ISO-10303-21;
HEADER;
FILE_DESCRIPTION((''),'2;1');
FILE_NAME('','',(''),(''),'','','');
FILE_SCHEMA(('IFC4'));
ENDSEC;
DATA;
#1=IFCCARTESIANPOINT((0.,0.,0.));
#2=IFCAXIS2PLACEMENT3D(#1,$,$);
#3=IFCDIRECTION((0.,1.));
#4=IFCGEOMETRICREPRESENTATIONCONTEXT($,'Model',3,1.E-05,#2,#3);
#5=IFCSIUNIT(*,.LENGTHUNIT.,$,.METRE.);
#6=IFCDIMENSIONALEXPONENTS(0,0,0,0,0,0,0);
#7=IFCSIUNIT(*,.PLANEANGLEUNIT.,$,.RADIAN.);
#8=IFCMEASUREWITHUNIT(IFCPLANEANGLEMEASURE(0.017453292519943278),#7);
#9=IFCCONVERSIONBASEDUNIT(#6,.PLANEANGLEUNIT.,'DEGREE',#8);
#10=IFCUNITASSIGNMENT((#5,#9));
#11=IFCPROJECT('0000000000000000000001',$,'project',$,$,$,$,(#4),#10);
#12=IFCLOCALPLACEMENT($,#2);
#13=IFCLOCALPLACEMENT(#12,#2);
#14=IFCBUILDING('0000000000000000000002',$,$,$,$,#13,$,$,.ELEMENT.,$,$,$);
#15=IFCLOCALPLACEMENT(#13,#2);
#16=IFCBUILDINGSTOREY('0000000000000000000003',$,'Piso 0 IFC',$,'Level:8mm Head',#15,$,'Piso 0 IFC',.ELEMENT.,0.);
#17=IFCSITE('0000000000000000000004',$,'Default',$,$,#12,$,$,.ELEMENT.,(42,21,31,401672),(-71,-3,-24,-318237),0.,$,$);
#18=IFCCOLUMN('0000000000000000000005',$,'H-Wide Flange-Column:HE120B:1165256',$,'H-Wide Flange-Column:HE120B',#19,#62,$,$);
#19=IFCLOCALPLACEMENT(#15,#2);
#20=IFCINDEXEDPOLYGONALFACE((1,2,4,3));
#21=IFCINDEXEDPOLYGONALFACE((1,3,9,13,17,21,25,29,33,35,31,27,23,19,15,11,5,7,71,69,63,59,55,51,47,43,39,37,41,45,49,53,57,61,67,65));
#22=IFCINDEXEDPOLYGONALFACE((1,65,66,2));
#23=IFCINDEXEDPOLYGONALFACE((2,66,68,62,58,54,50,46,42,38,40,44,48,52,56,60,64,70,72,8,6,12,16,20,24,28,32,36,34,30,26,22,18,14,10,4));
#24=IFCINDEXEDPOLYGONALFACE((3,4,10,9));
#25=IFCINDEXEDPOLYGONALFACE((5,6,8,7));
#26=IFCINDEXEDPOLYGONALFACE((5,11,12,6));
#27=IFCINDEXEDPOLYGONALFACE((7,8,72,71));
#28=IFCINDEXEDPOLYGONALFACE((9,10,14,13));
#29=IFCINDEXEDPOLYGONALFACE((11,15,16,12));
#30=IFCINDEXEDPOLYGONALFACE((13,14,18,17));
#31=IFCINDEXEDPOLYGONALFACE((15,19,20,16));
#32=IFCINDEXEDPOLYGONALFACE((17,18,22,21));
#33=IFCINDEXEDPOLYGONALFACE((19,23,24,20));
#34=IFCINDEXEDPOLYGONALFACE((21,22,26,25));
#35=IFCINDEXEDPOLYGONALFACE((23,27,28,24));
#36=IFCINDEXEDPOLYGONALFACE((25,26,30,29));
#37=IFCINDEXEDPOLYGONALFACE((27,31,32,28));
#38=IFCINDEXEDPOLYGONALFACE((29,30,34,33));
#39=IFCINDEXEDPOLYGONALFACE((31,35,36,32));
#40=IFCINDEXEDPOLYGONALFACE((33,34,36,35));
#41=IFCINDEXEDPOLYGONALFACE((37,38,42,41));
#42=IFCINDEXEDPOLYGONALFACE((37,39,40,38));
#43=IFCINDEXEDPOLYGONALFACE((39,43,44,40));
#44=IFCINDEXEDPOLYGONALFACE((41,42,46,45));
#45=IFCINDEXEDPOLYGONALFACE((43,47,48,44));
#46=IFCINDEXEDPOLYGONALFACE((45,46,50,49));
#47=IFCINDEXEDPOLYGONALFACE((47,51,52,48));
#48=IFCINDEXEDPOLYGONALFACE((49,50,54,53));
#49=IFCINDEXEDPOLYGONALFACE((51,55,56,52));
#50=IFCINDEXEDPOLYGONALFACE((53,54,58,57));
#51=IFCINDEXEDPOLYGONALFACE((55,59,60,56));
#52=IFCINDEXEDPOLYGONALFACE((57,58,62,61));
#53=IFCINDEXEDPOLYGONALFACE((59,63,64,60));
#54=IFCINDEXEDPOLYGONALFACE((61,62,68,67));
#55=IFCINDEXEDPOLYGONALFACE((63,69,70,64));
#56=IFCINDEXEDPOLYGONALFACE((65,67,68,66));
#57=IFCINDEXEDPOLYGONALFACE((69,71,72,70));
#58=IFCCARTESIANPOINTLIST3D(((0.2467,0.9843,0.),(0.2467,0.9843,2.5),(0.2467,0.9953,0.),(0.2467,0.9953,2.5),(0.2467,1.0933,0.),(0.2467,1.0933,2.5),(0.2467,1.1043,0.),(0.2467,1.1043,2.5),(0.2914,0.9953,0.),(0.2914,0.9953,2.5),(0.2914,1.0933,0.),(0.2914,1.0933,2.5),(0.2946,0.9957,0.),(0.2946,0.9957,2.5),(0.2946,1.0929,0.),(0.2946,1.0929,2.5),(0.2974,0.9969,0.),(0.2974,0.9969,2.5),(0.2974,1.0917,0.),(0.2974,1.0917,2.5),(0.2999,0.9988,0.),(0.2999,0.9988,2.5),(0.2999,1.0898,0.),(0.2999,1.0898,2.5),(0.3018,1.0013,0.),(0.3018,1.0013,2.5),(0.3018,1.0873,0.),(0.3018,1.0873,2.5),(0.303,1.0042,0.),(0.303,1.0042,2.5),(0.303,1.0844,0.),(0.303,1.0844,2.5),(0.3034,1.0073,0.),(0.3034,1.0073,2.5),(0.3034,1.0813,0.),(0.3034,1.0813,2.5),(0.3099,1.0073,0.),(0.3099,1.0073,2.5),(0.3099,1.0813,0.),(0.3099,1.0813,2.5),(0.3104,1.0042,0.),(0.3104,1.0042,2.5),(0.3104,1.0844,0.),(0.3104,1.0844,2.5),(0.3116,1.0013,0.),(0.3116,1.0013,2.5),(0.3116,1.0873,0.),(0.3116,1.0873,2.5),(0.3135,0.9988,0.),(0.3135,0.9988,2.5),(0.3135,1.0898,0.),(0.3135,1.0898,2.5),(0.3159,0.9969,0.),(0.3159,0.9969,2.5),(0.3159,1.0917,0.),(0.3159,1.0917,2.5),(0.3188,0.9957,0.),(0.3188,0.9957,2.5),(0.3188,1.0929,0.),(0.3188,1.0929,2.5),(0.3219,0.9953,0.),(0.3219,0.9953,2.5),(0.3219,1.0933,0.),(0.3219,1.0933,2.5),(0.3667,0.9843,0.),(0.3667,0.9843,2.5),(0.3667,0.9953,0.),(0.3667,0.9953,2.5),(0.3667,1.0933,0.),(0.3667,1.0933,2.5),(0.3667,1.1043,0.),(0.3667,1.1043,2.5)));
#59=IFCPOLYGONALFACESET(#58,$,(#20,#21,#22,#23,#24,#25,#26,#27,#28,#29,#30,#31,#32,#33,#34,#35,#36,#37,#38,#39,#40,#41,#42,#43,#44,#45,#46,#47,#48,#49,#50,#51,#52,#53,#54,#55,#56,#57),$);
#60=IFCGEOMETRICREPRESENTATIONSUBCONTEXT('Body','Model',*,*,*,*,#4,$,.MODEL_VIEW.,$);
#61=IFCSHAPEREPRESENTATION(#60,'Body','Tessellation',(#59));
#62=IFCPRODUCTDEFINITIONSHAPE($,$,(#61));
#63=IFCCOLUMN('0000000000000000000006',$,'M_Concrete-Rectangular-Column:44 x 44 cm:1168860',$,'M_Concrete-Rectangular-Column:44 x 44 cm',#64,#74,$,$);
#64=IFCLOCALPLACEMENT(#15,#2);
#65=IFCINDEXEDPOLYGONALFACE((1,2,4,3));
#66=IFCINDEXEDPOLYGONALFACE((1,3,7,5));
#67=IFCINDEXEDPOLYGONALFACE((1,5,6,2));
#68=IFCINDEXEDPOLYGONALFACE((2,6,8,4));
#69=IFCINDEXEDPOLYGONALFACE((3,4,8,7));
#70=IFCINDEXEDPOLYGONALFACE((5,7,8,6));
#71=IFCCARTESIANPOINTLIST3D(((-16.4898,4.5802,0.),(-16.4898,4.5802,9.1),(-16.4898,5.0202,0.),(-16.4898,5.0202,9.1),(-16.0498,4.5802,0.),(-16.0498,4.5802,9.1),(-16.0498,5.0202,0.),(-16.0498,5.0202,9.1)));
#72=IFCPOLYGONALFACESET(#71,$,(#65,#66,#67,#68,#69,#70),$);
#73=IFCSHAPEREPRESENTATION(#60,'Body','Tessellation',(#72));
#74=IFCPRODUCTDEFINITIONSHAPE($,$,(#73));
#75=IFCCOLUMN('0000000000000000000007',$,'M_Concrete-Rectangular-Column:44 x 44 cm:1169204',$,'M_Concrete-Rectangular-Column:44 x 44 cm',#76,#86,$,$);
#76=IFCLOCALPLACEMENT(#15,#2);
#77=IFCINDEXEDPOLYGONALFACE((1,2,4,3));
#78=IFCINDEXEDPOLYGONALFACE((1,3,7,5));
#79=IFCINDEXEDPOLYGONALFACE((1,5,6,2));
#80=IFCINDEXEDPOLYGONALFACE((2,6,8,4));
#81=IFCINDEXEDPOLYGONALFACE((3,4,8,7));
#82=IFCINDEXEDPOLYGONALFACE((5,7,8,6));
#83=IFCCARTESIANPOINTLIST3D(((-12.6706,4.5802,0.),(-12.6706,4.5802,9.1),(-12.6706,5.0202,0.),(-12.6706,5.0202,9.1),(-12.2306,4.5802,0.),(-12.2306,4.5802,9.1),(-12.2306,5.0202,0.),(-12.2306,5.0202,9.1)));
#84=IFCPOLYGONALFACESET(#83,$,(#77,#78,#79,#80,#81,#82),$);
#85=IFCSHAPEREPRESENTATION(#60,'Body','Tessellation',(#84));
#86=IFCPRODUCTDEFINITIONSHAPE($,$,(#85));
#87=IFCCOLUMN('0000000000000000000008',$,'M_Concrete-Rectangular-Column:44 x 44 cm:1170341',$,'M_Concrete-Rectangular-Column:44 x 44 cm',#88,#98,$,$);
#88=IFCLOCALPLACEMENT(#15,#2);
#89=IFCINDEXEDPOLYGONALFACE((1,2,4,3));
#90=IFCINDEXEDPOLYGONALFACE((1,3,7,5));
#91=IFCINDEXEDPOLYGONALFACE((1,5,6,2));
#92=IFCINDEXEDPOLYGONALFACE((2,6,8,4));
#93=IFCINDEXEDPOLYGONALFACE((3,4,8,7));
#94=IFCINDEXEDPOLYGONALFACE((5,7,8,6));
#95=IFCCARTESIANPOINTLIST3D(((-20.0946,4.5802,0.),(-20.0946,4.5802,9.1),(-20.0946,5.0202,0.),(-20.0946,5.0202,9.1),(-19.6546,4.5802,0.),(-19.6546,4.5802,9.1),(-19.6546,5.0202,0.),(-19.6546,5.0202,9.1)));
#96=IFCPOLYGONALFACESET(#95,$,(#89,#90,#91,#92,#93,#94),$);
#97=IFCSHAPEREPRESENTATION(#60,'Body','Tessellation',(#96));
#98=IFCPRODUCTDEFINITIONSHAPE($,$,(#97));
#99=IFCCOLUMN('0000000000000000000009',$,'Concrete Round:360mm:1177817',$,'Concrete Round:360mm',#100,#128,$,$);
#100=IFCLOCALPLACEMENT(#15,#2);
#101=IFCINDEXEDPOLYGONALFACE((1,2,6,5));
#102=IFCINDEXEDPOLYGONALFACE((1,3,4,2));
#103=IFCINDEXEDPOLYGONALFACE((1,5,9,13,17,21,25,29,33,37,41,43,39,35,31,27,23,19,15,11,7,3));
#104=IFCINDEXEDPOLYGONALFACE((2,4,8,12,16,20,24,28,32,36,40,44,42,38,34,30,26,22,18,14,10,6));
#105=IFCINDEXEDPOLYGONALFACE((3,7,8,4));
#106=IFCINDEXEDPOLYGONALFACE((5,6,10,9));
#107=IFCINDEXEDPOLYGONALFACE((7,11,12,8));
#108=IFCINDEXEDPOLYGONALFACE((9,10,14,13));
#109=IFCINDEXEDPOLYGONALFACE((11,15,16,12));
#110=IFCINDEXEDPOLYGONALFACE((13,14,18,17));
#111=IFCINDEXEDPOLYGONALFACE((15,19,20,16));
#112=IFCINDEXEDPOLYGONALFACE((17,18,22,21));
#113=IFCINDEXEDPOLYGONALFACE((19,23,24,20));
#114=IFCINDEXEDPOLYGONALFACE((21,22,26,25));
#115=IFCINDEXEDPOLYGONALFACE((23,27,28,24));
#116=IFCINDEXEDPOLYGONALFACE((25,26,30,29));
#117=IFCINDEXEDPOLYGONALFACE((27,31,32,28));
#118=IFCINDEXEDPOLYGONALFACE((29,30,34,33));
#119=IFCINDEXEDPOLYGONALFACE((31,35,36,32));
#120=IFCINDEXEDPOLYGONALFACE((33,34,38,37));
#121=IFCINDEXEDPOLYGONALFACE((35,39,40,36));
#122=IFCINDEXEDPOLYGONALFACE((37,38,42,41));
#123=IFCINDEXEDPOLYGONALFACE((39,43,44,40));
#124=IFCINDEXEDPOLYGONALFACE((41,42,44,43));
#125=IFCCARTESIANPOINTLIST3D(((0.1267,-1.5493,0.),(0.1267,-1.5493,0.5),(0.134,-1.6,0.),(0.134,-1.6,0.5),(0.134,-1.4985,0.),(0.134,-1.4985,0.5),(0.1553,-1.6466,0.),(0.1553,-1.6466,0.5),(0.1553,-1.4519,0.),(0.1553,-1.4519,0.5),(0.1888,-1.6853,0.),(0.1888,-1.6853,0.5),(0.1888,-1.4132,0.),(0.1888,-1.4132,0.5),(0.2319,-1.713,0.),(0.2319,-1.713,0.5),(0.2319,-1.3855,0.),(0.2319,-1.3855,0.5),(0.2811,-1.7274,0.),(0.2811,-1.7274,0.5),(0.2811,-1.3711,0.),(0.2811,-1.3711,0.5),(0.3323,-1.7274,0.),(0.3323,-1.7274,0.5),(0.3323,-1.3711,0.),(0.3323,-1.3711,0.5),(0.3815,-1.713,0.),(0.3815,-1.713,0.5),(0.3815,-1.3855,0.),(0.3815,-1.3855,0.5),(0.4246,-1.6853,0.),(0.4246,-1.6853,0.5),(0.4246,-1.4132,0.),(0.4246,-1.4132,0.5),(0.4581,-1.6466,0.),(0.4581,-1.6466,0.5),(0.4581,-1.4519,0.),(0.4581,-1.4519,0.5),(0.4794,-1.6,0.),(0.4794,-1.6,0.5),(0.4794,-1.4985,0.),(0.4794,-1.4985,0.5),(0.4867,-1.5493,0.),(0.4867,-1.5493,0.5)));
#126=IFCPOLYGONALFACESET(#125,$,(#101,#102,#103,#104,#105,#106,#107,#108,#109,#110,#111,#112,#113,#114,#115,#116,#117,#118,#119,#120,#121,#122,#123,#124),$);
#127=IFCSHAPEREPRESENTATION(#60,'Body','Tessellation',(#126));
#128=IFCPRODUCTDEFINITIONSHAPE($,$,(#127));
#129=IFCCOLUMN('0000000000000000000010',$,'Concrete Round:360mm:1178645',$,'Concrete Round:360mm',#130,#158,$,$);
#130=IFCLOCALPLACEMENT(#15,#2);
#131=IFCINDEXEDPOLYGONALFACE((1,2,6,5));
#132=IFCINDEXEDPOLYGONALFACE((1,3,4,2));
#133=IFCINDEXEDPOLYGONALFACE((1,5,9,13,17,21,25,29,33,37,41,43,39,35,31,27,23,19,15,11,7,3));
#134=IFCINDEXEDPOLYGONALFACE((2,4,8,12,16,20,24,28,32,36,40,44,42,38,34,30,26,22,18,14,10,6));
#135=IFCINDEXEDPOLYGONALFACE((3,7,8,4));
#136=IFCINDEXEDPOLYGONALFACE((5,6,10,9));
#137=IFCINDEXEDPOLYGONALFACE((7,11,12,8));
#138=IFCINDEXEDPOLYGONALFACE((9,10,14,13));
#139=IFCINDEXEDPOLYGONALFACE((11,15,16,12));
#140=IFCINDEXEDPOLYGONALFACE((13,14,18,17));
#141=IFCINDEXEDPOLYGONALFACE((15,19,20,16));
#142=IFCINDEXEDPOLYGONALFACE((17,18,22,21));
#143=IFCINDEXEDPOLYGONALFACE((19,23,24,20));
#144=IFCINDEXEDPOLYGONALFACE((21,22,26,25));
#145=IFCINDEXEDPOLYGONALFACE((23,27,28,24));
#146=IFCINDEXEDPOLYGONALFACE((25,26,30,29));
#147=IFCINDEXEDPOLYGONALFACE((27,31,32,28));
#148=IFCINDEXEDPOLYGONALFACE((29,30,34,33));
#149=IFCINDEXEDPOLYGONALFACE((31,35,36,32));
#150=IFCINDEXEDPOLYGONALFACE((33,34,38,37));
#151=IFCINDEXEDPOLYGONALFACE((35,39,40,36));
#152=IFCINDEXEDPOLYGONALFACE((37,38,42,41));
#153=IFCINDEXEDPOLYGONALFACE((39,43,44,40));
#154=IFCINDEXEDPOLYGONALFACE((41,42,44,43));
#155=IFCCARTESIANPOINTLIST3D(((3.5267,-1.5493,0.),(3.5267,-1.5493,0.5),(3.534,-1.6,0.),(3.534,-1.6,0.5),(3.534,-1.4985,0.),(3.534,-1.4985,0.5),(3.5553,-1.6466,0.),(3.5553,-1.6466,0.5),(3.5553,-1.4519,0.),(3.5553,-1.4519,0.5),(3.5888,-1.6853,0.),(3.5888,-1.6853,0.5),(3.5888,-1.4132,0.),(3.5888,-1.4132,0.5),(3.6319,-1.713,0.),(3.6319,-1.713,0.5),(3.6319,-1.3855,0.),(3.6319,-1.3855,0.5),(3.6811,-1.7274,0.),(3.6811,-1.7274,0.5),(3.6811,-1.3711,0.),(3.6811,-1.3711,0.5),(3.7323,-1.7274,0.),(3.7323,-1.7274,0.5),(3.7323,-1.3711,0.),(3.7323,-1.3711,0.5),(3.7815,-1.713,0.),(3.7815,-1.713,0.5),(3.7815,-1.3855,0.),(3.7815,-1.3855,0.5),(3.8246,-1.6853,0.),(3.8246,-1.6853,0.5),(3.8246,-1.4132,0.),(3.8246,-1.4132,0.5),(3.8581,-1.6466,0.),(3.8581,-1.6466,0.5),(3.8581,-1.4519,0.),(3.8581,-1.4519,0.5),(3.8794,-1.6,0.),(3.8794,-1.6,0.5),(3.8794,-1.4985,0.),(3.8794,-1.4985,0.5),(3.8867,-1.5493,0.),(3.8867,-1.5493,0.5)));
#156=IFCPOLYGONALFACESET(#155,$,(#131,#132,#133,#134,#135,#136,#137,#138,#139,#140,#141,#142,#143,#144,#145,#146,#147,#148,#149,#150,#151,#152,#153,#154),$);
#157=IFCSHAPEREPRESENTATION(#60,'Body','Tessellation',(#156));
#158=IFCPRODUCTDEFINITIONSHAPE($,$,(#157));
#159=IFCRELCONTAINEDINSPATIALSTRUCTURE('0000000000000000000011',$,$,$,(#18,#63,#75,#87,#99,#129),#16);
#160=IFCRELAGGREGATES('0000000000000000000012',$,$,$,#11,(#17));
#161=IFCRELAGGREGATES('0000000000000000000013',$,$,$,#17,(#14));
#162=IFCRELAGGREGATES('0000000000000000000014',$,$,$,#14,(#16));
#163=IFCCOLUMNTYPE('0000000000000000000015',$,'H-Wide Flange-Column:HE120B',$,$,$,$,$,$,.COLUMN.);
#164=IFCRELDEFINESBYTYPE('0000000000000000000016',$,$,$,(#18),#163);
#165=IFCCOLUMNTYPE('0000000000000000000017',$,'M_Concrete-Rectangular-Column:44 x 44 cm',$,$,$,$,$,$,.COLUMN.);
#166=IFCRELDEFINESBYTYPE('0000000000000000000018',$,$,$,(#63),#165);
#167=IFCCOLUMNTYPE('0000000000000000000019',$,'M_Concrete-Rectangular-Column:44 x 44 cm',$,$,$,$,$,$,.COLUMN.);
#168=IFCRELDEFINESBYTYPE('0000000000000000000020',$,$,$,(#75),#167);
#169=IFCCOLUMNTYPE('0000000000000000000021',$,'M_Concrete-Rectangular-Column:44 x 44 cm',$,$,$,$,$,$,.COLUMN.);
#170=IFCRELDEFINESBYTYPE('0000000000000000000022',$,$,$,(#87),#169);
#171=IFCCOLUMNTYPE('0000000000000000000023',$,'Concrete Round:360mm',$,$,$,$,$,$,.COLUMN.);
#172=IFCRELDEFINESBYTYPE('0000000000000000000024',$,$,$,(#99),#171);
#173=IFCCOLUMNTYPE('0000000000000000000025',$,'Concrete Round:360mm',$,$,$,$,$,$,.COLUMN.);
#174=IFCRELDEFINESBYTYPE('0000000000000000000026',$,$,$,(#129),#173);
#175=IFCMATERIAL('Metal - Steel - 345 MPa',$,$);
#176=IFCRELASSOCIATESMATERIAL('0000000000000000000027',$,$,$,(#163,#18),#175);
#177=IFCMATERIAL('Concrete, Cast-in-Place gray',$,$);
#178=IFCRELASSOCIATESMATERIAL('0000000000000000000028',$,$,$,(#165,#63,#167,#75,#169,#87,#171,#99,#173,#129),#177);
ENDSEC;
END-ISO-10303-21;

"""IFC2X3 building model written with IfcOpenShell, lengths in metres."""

from ifc_helpers import new_model, entity, si_unit, converted_unit, direction, frame, frame_2d, origin, place, context, subcontext, project, spatial, rectangle, circle, i_section, extrude, source, transform, mapped, material, type_object, type_shapes, element, save


model = new_model("IFC2X3")

# Units and contexts
model_context = context("Model", 3, precision=1e-05, world=origin(), true_north=direction((0.0, 1.0)))
body_context = subcontext(model_context, "Body", "Model", "MODEL_VIEW")
ifc_project = project(units=[si_unit("LENGTHUNIT", "METRE"), converted_unit("PLANEANGLEUNIT", "DEGREE", entity("IfcPlaneAngleMeasure", 0.017453292519943278), si_unit("PLANEANGLEUNIT", "RADIAN"), dimensions=[0, 0, 0, 0, 0, 0, 0])], contexts=[model_context])

# Site, building, storey
site_placement = place(None, origin())
site = spatial("IfcSite", under=ifc_project, at=site_placement, Name="Default", CompositionType="ELEMENT", RefLatitude=(42, 21, 31, 401672), RefLongitude=(-71, -3, -24, -318237), RefElevation=0.0)
building_placement = place(site_placement, origin())
building = spatial("IfcBuilding", under=site, at=building_placement, CompositionType="ELEMENT")
storey_placement = place(building_placement, origin())
storey = spatial("IfcBuildingStorey", under=building, at=storey_placement, Name="Piso 0 IFC", ObjectType="Level:8mm Head", LongName="Piso 0 IFC", CompositionType="ELEMENT", Elevation=0.0)

# Columns
ifc_material_1 = material(Name="Metal - Steel - 345 MPa")
column_type_1 = type_object("IfcColumnType", Name="H-Wide Flange-Column:HE120B", PredefinedType="COLUMN", material=ifc_material_1)
shared_shape_1 = source(origin(), body_context, "Body", "SweptSolid", [
    extrude(i_section(OverallWidth=0.12, OverallDepth=0.12, WebThickness=0.0065, FlangeThickness=0.011, FilletRadius=0.012, at=frame_2d((0.0, 0.0), x_axis=(1.0, 0.0))), frame((0.0, 0.0, 0.0), z_axis=(0.0, 0.0, 1.0), x_axis=(-1.0, 0.0, 0.0)), (0.0, 0.0, 1.0), 2.5),
])
type_shapes(column_type_1, [shared_shape_1])
column_1_placement = place(storey_placement, frame((0.3067, 1.0443, 0.0)))
element("IfcColumn", 1, at=column_1_placement, inside=storey, type_object=column_type_1, material=ifc_material_1, Name="H-Wide Flange-Column:HE120B:1165256", ObjectType="H-Wide Flange-Column:HE120B", context=body_context, shape_type="MappedRepresentation", body=[
    mapped(shared_shape_1, transform((0.0, 0.0, 0.0), scale=1.0)),
])
ifc_material_2 = material(Name="Concrete, Cast-in-Place gray")
column_type_2 = type_object("IfcColumnType", Name="M_Concrete-Rectangular-Column:44 x 44 cm", PredefinedType="COLUMN", material=ifc_material_2)
shared_shape_2 = source(origin(), body_context, "Body", "SweptSolid", [
    extrude(rectangle(XDim=0.44, YDim=0.44, at=frame_2d((0.0, 0.0), x_axis=(1.0, 0.0))), frame((-16.2698, 4.8002, 0.0), z_axis=(0.0, 0.0, 1.0), x_axis=(-1.0, 0.0, 0.0)), (0.0, 0.0, 1.0), 9.1),
])
type_shapes(column_type_2, [shared_shape_2])
column_2_placement = place(storey_placement, origin())
element("IfcColumn", 2, at=column_2_placement, inside=storey, type_object=column_type_2, material=ifc_material_2, Name="M_Concrete-Rectangular-Column:44 x 44 cm:1168860", ObjectType="M_Concrete-Rectangular-Column:44 x 44 cm", context=body_context, shape_type="MappedRepresentation", body=[
    mapped(shared_shape_2, transform((0.0, 0.0, 0.0), scale=1.0)),
])
column_type_3 = type_object("IfcColumnType", Name="M_Concrete-Rectangular-Column:44 x 44 cm", PredefinedType="COLUMN", material=ifc_material_2)
shared_shape_3 = source(origin(), body_context, "Body", "SweptSolid", [
    extrude(rectangle(XDim=0.44, YDim=0.44, at=frame_2d((0.0, 0.0), x_axis=(1.0, 0.0))), frame((-12.4506, 4.8002, 0.0), z_axis=(0.0, 0.0, 1.0), x_axis=(-1.0, 0.0, 0.0)), (0.0, 0.0, 1.0), 9.1),
])
type_shapes(column_type_3, [shared_shape_3])
column_3_placement = place(storey_placement, origin())
element("IfcColumn", 3, at=column_3_placement, inside=storey, type_object=column_type_3, material=ifc_material_2, Name="M_Concrete-Rectangular-Column:44 x 44 cm:1169204", ObjectType="M_Concrete-Rectangular-Column:44 x 44 cm", context=body_context, shape_type="MappedRepresentation", body=[
    mapped(shared_shape_3, transform((0.0, 0.0, 0.0), scale=1.0)),
])
column_type_4 = type_object("IfcColumnType", Name="M_Concrete-Rectangular-Column:44 x 44 cm", PredefinedType="COLUMN", material=ifc_material_2)
shared_shape_4 = source(origin(), body_context, "Body", "SweptSolid", [
    extrude(rectangle(XDim=0.44, YDim=0.44, at=frame_2d((0.0, 0.0), x_axis=(1.0, 0.0))), frame((-19.8746, 4.8002, 0.0), z_axis=(0.0, 0.0, 1.0), x_axis=(-1.0, 0.0, 0.0)), (0.0, 0.0, 1.0), 9.1),
])
type_shapes(column_type_4, [shared_shape_4])
column_4_placement = place(storey_placement, origin())
element("IfcColumn", 4, at=column_4_placement, inside=storey, type_object=column_type_4, material=ifc_material_2, Name="M_Concrete-Rectangular-Column:44 x 44 cm:1170341", ObjectType="M_Concrete-Rectangular-Column:44 x 44 cm", context=body_context, shape_type="MappedRepresentation", body=[
    mapped(shared_shape_4, transform((0.0, 0.0, 0.0), scale=1.0)),
])
column_type_5 = type_object("IfcColumnType", Name="Concrete Round:360mm", PredefinedType="COLUMN", material=ifc_material_2)
shared_shape_5 = source(origin(), body_context, "Body", "SweptSolid", [
    extrude(circle(Radius=0.18, at=frame_2d((0.0, 0.0), x_axis=(1.0, 0.0))), frame((0.3067, -1.5493, 0.0)), (0.0, 0.0, 1.0), 0.5),
])
type_shapes(column_type_5, [shared_shape_5])
column_5_placement = place(storey_placement, origin())
element("IfcColumn", 5, at=column_5_placement, inside=storey, type_object=column_type_5, material=ifc_material_2, Name="Concrete Round:360mm:1177817", ObjectType="Concrete Round:360mm", context=body_context, shape_type="MappedRepresentation", body=[
    mapped(shared_shape_5, transform((0.0, 0.0, 0.0), scale=1.0)),
])
column_type_6 = type_object("IfcColumnType", Name="Concrete Round:360mm", PredefinedType="COLUMN", material=ifc_material_2)
shared_shape_6 = source(origin(), body_context, "Body", "SweptSolid", [
    extrude(circle(Radius=0.18, at=frame_2d((0.0, 0.0), x_axis=(1.0, 0.0))), frame((3.7067, -1.5493, 0.0)), (0.0, 0.0, 1.0), 0.5),
])
type_shapes(column_type_6, [shared_shape_6])
column_6_placement = place(storey_placement, origin())
element("IfcColumn", 6, at=column_6_placement, inside=storey, type_object=column_type_6, material=ifc_material_2, Name="Concrete Round:360mm:1178645", ObjectType="Concrete Round:360mm", context=body_context, shape_type="MappedRepresentation", body=[
    mapped(shared_shape_6, transform((0.0, 0.0, 0.0), scale=1.0)),
])

save(model, "model.ifc")
